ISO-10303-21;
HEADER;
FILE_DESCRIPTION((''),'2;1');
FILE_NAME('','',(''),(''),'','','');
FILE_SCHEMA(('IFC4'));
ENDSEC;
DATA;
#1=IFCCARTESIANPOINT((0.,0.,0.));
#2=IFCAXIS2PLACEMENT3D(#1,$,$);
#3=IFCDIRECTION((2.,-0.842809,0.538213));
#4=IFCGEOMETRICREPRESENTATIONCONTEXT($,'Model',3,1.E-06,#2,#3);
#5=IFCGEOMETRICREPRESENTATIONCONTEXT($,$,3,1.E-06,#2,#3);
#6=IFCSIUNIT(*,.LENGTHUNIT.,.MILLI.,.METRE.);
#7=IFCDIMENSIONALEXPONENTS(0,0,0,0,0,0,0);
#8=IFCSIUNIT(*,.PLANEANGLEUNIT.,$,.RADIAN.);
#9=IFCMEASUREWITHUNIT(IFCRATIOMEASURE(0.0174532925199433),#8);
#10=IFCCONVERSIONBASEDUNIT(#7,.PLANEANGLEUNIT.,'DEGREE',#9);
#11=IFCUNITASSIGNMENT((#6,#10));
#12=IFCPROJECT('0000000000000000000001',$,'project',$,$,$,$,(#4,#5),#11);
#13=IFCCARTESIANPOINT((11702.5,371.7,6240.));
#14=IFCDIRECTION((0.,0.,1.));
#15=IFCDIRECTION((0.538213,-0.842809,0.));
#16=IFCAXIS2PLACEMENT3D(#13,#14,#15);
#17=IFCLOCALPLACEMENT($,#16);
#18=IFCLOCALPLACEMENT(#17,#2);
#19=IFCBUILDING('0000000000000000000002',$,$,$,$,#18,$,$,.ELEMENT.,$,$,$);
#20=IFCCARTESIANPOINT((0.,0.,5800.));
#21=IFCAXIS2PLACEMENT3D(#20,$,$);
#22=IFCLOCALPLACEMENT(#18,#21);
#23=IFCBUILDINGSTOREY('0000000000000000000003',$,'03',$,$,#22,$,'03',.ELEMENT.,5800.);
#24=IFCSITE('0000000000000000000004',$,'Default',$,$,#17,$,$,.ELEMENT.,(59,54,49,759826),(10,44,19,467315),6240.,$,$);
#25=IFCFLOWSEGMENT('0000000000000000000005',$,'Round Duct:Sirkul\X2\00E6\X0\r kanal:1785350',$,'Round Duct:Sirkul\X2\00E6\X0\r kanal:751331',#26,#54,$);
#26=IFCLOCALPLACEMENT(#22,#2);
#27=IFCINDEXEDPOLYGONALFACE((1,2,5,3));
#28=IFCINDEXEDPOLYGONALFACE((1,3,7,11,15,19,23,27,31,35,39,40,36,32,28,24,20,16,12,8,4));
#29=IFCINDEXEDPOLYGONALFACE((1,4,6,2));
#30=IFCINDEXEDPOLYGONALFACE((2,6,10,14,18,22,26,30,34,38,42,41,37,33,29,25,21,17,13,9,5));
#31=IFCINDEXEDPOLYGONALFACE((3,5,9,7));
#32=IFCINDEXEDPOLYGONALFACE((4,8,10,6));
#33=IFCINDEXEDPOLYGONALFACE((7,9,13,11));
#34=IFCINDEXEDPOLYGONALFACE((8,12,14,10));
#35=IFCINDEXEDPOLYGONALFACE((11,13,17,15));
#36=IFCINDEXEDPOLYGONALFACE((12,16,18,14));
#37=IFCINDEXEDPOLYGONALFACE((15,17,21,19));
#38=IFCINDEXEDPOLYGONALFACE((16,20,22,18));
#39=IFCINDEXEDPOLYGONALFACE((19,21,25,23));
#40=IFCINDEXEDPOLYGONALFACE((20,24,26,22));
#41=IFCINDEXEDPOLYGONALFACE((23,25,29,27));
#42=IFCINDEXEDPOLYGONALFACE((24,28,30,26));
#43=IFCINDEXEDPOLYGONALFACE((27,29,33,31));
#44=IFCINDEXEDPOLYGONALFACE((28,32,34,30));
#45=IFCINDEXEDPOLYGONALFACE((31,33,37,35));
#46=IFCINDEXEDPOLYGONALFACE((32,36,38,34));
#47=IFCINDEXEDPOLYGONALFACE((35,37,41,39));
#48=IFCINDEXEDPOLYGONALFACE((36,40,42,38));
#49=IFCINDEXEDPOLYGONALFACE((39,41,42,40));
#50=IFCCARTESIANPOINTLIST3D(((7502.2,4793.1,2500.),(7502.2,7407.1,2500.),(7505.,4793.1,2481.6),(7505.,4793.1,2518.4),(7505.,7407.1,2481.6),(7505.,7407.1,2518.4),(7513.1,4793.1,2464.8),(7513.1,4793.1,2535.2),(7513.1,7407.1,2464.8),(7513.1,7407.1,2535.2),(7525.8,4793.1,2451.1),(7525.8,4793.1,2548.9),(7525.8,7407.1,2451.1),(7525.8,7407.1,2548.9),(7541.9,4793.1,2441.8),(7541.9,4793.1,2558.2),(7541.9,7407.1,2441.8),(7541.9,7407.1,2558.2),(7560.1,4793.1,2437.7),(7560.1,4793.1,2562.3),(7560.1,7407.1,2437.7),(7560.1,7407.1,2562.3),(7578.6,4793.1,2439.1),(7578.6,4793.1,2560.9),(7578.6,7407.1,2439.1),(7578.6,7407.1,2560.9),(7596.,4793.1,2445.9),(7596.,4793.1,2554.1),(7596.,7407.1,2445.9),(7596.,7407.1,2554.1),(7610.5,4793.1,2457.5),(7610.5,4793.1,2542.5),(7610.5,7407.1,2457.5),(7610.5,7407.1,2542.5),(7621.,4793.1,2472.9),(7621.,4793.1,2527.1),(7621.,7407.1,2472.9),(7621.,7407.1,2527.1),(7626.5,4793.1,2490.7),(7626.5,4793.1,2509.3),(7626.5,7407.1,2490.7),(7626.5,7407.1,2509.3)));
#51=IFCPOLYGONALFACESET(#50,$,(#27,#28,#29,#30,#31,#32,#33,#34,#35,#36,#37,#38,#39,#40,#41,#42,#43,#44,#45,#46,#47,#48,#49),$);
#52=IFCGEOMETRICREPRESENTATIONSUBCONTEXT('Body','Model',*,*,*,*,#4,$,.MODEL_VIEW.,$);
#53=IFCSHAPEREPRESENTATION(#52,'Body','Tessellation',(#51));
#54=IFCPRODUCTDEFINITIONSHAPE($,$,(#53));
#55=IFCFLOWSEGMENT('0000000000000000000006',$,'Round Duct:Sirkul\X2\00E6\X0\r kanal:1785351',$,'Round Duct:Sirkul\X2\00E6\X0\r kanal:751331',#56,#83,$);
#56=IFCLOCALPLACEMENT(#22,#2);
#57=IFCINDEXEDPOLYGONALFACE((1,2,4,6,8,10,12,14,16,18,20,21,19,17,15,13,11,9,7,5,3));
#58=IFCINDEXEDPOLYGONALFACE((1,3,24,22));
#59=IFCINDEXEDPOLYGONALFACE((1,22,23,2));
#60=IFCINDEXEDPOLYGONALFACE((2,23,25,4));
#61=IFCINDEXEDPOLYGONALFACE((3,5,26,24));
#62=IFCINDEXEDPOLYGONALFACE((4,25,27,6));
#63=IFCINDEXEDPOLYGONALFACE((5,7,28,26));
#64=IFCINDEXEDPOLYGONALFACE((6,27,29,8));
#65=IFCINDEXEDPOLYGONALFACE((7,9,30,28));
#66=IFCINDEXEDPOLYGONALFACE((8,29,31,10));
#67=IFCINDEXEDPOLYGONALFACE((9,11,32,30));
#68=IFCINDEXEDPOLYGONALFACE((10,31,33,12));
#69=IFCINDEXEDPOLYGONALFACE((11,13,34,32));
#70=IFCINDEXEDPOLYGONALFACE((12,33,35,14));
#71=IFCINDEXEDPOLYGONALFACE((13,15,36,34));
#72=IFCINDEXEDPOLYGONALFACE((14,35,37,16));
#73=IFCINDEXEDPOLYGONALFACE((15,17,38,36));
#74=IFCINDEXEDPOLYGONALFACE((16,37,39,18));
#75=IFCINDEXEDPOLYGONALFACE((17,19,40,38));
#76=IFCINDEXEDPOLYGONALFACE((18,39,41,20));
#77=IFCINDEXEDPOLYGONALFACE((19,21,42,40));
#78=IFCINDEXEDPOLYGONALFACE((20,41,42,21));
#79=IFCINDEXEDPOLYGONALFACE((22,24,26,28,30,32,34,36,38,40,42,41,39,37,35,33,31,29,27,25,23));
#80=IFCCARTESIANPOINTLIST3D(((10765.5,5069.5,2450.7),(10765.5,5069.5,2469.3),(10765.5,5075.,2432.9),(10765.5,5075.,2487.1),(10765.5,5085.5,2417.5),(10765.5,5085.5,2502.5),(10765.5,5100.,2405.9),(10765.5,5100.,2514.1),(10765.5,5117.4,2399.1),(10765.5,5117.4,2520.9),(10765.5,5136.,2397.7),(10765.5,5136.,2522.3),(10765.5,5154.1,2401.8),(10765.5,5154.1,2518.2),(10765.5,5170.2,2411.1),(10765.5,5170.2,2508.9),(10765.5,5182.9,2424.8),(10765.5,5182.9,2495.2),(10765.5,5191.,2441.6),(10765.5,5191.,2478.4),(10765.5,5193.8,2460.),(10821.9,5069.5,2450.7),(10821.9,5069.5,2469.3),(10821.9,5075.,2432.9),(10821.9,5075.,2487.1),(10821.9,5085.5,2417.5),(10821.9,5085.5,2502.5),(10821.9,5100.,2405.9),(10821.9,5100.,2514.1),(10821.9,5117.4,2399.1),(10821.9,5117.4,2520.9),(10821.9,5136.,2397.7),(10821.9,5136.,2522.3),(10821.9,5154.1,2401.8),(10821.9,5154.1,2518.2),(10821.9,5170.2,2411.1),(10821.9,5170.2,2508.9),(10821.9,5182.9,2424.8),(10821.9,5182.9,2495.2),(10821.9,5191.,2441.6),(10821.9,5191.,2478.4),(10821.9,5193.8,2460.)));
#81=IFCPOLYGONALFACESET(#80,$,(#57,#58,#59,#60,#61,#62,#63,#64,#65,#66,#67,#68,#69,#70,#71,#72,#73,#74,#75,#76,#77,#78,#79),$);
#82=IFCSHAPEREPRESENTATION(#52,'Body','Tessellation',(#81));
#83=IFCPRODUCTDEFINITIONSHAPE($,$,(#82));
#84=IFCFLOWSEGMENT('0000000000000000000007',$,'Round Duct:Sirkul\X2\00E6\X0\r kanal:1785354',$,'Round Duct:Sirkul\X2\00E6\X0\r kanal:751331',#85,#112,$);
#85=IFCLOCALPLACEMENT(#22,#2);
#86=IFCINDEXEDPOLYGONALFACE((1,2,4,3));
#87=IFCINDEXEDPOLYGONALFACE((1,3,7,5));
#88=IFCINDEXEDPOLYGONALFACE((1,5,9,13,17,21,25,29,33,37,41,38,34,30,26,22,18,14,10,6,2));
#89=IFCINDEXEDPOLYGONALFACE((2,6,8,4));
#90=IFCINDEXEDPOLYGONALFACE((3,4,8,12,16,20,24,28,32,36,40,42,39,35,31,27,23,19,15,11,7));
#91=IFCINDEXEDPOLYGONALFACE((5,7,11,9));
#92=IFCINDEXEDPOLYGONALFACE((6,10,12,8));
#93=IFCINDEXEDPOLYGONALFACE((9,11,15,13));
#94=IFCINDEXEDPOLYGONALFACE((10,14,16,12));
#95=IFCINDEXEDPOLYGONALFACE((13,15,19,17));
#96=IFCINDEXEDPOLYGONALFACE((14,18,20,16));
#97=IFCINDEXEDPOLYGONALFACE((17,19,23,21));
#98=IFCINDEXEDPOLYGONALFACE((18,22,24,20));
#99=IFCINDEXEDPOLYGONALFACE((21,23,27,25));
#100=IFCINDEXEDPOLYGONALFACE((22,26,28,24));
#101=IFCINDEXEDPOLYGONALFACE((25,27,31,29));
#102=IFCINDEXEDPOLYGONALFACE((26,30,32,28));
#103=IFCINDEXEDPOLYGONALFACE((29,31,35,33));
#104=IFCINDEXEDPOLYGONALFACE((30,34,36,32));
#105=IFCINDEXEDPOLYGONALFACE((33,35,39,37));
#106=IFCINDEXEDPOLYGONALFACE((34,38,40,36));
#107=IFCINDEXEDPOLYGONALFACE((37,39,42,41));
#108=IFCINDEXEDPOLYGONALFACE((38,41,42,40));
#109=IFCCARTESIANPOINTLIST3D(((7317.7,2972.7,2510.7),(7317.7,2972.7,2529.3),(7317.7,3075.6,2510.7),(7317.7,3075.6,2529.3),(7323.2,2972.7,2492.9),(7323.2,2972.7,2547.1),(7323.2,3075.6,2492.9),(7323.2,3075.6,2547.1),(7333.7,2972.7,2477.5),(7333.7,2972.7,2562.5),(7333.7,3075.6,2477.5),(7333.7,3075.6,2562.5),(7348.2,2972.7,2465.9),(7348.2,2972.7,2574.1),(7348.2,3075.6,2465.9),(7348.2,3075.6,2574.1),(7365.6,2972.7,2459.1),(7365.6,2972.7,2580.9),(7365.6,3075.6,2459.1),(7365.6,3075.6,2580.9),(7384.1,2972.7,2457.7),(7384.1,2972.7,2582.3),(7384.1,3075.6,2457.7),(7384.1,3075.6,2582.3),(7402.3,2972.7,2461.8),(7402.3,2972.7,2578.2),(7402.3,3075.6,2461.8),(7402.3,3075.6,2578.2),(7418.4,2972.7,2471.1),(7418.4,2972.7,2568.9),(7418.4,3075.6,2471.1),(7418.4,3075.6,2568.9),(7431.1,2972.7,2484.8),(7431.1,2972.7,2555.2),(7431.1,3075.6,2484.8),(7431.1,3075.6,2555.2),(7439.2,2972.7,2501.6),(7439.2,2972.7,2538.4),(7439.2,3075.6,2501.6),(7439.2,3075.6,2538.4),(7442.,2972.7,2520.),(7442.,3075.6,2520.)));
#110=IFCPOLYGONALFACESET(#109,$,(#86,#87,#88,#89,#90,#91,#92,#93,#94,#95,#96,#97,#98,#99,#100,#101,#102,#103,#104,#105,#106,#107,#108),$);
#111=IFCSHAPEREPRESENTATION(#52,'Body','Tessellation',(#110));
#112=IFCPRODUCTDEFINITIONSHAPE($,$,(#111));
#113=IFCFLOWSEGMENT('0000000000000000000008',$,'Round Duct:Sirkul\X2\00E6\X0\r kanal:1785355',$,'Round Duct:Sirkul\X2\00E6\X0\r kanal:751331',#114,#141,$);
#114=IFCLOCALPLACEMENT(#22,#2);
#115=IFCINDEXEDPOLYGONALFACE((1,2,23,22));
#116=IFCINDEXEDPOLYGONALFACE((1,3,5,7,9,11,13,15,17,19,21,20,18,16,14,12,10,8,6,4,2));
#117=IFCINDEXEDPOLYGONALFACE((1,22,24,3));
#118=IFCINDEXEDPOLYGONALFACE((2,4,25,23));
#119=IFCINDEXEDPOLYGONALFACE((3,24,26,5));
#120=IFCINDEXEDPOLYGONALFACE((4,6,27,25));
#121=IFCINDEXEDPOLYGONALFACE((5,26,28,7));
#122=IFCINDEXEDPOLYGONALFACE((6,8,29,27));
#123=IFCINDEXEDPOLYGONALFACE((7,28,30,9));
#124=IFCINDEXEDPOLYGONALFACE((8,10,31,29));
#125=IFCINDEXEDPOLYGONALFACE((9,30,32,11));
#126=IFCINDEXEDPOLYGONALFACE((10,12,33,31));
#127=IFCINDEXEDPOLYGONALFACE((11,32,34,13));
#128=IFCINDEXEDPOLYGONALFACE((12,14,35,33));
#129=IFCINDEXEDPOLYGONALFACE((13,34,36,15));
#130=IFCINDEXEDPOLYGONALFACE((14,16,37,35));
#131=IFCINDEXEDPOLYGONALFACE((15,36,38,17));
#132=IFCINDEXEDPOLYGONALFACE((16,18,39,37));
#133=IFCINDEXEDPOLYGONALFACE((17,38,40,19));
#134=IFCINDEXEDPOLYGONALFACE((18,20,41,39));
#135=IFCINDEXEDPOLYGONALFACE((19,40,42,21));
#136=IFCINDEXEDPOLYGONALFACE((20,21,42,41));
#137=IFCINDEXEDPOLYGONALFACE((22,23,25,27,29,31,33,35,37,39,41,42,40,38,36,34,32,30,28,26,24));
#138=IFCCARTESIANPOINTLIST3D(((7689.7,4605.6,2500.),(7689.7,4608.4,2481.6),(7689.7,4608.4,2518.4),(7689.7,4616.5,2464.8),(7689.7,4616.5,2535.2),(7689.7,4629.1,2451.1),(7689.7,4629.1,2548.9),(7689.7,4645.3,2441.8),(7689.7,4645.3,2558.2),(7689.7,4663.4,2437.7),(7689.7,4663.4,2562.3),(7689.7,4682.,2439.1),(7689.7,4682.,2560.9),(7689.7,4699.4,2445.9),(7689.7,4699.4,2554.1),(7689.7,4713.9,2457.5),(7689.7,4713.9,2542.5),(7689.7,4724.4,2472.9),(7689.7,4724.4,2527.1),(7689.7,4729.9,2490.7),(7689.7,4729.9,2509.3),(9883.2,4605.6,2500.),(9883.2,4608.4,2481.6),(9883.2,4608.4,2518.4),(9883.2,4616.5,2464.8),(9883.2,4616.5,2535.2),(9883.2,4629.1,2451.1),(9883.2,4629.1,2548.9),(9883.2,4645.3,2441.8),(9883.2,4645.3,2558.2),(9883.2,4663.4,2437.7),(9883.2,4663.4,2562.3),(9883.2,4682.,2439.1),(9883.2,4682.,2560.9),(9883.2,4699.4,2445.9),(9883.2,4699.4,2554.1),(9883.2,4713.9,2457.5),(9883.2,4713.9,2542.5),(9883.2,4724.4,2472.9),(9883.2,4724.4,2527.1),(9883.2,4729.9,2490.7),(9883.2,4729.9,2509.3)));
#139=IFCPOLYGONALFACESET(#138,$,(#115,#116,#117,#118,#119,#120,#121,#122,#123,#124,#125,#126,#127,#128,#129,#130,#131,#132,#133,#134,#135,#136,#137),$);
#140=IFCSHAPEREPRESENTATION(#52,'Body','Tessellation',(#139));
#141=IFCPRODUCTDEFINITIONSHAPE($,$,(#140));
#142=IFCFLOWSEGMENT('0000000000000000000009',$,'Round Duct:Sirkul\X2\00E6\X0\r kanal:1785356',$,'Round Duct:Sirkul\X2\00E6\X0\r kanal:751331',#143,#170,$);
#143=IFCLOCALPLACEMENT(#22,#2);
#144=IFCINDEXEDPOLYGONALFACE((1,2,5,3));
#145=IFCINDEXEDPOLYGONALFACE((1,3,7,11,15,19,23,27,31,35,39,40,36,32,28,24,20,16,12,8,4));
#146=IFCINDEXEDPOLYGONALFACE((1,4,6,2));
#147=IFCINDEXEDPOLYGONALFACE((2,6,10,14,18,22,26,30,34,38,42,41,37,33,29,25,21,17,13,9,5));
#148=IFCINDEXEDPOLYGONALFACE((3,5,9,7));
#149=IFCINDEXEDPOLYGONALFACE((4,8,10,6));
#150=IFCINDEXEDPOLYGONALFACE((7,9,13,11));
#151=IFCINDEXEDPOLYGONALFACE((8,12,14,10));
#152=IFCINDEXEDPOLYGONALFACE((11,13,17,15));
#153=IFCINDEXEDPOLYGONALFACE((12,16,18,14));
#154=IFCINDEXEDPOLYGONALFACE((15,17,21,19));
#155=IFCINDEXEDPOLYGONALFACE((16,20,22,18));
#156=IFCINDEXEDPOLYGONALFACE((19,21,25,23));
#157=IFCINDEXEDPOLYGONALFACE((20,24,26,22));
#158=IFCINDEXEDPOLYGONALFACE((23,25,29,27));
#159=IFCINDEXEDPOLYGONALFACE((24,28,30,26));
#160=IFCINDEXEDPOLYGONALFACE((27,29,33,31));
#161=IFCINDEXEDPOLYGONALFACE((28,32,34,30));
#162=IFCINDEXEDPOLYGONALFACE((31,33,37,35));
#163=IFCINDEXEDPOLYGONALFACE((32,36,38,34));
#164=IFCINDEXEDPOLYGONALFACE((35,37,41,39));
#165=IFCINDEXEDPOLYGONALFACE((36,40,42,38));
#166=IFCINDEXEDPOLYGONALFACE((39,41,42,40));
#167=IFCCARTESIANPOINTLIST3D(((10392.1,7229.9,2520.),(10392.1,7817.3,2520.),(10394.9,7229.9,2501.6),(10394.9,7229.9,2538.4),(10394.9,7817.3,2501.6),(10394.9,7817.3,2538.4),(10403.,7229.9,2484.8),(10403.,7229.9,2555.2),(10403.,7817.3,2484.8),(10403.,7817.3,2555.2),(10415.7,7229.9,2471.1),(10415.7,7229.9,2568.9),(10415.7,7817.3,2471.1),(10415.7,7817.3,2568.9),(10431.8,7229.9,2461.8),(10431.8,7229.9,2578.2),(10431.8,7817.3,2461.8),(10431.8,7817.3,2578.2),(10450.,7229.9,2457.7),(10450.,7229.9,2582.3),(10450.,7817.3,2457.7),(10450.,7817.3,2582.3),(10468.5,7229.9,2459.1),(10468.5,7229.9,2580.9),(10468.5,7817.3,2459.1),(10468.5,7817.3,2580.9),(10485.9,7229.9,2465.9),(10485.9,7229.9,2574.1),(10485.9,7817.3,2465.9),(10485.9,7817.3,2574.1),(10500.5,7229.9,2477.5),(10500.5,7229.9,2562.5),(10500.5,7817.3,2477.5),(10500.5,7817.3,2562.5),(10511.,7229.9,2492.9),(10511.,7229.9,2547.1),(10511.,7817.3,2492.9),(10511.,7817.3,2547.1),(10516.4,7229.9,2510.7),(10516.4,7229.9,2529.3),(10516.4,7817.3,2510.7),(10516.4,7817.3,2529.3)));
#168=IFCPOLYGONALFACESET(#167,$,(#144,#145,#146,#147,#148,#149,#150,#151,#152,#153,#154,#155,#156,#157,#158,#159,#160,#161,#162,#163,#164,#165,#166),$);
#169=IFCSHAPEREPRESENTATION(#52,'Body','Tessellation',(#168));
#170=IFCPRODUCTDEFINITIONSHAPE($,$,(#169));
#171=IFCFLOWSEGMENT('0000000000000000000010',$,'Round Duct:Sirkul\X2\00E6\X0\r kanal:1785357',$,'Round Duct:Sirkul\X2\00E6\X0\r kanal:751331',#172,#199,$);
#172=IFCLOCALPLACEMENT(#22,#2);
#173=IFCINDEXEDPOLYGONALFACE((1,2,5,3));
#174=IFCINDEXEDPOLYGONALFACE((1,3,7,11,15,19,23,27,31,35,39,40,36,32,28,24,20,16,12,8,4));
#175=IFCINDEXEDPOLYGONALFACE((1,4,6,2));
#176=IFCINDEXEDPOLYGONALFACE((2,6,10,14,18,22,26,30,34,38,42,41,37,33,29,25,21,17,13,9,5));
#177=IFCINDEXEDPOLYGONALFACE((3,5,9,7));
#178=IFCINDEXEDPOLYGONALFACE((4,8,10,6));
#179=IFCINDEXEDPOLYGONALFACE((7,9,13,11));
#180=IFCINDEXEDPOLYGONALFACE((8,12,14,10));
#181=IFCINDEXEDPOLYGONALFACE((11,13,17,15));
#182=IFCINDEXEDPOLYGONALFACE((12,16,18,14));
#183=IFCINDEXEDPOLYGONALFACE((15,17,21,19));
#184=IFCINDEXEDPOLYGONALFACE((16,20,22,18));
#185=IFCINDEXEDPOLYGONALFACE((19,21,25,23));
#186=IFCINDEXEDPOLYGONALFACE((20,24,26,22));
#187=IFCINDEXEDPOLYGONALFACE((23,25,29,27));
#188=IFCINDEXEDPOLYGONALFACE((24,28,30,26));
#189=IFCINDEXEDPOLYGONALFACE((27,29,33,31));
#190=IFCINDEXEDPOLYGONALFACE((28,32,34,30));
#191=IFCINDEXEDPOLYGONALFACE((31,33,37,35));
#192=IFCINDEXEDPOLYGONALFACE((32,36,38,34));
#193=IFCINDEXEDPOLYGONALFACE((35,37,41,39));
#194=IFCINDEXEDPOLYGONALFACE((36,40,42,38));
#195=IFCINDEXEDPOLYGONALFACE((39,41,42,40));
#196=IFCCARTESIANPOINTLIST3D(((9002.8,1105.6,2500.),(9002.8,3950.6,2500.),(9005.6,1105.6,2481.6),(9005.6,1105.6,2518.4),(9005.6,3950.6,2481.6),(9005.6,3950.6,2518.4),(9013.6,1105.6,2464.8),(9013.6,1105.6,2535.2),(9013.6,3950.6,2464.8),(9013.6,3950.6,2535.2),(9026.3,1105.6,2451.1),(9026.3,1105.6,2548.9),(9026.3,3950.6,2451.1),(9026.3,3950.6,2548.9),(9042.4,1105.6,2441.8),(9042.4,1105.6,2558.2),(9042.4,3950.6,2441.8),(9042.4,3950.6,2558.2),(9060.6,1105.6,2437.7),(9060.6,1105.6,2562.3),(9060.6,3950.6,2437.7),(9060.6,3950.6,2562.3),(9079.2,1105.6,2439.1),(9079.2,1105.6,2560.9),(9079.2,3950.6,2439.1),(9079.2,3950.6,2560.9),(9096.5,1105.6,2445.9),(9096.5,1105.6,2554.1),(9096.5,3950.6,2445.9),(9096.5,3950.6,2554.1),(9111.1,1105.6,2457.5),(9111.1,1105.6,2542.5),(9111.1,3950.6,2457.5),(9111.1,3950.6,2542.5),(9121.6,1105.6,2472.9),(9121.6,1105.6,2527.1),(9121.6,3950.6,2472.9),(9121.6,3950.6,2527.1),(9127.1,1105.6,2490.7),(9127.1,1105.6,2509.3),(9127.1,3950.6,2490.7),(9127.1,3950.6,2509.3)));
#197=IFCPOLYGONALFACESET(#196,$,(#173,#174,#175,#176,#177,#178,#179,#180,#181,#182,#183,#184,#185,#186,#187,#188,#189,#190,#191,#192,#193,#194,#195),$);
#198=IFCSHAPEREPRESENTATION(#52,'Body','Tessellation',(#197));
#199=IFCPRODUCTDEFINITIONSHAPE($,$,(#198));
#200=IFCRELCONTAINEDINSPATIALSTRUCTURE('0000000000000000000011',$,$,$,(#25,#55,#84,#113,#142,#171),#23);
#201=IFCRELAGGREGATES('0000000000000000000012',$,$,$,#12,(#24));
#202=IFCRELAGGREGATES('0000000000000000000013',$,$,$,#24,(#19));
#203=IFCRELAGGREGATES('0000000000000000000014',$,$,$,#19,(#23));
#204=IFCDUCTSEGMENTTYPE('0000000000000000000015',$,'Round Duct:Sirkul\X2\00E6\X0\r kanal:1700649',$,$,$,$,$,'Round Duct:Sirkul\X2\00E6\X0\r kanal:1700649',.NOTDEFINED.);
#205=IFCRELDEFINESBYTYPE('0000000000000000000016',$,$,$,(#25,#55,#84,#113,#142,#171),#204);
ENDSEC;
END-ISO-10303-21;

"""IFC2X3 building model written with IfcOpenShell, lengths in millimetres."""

from ifc_helpers import new_model, entity, si_unit, converted_unit, direction, frame, frame_2d, origin, origin_2d_with_axis, place, context, subcontext, project, spatial, circle, extrude, type_object, element, save


model = new_model("IFC2X3")

# Units and contexts
model_context = context("Model", 3, precision=1e-06, world=origin(), true_north=direction((2.0, -0.842809, 0.538213)))
context_of_model = context(None, 3, precision=1e-06, world=origin(), true_north=direction((2.0, -0.842809, 0.538213)))
body_context = subcontext(model_context, "Body", "Model", "MODEL_VIEW")
ifc_project = project(units=[si_unit("LENGTHUNIT", "METRE", prefix="MILLI"), converted_unit("PLANEANGLEUNIT", "DEGREE", entity("IfcRatioMeasure", 0.0174532925199433), si_unit("PLANEANGLEUNIT", "RADIAN"), dimensions=[0, 0, 0, 0, 0, 0, 0])], contexts=[model_context, context_of_model])

# Site, building, storey
site_placement = place(None, frame((11702.5, 371.7, 6240.0), z_axis=(0.0, 0.0, 1.0), x_axis=(0.538213, -0.842809, 0.0)))
site = spatial("IfcSite", under=ifc_project, at=site_placement, Name="Default", CompositionType="ELEMENT", RefLatitude=(59, 54, 49, 759826), RefLongitude=(10, 44, 19, 467315), RefElevation=6240.0)
building_placement = place(site_placement, origin())
building = spatial("IfcBuilding", under=site, at=building_placement, CompositionType="ELEMENT")
storey_placement = place(building_placement, frame((0.0, 0.0, 5800.0)))
storey = spatial("IfcBuildingStorey", under=building, at=storey_placement, Name="03", LongName="03", CompositionType="ELEMENT", Elevation=5800.0)

# Flow segments
duct_segment_type = type_object("IfcDuctSegmentType", Name="Round Duct:Sirkulær kanal:1700649", ElementType="Round Duct:Sirkulær kanal:1700649", PredefinedType="NOTDEFINED")
flow_segment_1_placement = place(storey_placement, origin())
element("IfcFlowSegment", 1, at=flow_segment_1_placement, inside=storey, type_object=duct_segment_type, Name="Round Duct:Sirkulær kanal:1785350", ObjectType="Round Duct:Sirkulær kanal:751331", context=body_context, shape_type="SweptSolid", body=[
    extrude(circle(Radius=62.5, at=frame_2d((0.0, 0.0), x_axis=(1.0, 0.0))), frame((7564.7, 4793.1, 2500.0), z_axis=(0.0, 1.0, 0.0), x_axis=(-1.0, 0.0, 0.0)), (0.0, 0.0, 1.0), 2614.0),
])
flow_segment_2_placement = place(storey_placement, origin())
element("IfcFlowSegment", 2, at=flow_segment_2_placement, inside=storey, type_object=duct_segment_type, Name="Round Duct:Sirkulær kanal:1785351", ObjectType="Round Duct:Sirkulær kanal:751331", context=body_context, shape_type="SweptSolid", body=[
    extrude(circle(Radius=62.5, at=frame_2d((0.0, 0.0), x_axis=(1.0, 0.0))), frame((10765.5, 5131.3, 2460.0), z_axis=(1.0, 0.0, 0.0), x_axis=(0.0, 1.0, 0.0)), (0.0, 0.0, 1.0), 56.4),
])
flow_segment_3_placement = place(storey_placement, origin())
element("IfcFlowSegment", 3, at=flow_segment_3_placement, inside=storey, type_object=duct_segment_type, Name="Round Duct:Sirkulær kanal:1785354", ObjectType="Round Duct:Sirkulær kanal:751331", context=body_context, shape_type="SweptSolid", body=[
    extrude(circle(Radius=62.5, at=origin_2d_with_axis()), frame((7379.5, 2972.7, 2520.0), z_axis=(0.0, 1.0, 0.0), x_axis=(1.0, 0.0, 0.0)), (0.0, 0.0, 1.0), 102.9),
])
flow_segment_4_placement = place(storey_placement, origin())
element("IfcFlowSegment", 4, at=flow_segment_4_placement, inside=storey, type_object=duct_segment_type, Name="Round Duct:Sirkulær kanal:1785355", ObjectType="Round Duct:Sirkulær kanal:751331", context=body_context, shape_type="SweptSolid", body=[
    extrude(circle(Radius=62.5, at=frame_2d((0.0, 0.0), x_axis=(1.0, 0.0))), frame((7689.7, 4668.1, 2500.0), z_axis=(1.0, 0.0, 0.0), x_axis=(0.0, -1.0, 0.0)), (0.0, 0.0, 1.0), 2193.4),
])
flow_segment_5_placement = place(storey_placement, origin())
element("IfcFlowSegment", 5, at=flow_segment_5_placement, inside=storey, type_object=duct_segment_type, Name="Round Duct:Sirkulær kanal:1785356", ObjectType="Round Duct:Sirkulær kanal:751331", context=body_context, shape_type="SweptSolid", body=[
    extrude(circle(Radius=62.5, at=frame_2d((0.0, 0.0), x_axis=(1.0, 0.0))), frame((10454.6, 7229.9, 2520.0), z_axis=(0.0, 1.0, 0.0), x_axis=(-1.0, 0.0, 0.0)), (0.0, 0.0, 1.0), 587.5),
])
flow_segment_6_placement = place(storey_placement, origin())
element("IfcFlowSegment", 6, at=flow_segment_6_placement, inside=storey, type_object=duct_segment_type, Name="Round Duct:Sirkulær kanal:1785357", ObjectType="Round Duct:Sirkulær kanal:751331", context=body_context, shape_type="SweptSolid", body=[
    extrude(circle(Radius=62.5, at=frame_2d((0.0, 0.0), x_axis=(1.0, 0.0))), frame((9065.3, 1105.6, 2500.0), z_axis=(0.0, 1.0, 0.0), x_axis=(-1.0, 0.0, 0.0)), (0.0, 0.0, 1.0), 2845.0),
])

save(model, "model.ifc")
